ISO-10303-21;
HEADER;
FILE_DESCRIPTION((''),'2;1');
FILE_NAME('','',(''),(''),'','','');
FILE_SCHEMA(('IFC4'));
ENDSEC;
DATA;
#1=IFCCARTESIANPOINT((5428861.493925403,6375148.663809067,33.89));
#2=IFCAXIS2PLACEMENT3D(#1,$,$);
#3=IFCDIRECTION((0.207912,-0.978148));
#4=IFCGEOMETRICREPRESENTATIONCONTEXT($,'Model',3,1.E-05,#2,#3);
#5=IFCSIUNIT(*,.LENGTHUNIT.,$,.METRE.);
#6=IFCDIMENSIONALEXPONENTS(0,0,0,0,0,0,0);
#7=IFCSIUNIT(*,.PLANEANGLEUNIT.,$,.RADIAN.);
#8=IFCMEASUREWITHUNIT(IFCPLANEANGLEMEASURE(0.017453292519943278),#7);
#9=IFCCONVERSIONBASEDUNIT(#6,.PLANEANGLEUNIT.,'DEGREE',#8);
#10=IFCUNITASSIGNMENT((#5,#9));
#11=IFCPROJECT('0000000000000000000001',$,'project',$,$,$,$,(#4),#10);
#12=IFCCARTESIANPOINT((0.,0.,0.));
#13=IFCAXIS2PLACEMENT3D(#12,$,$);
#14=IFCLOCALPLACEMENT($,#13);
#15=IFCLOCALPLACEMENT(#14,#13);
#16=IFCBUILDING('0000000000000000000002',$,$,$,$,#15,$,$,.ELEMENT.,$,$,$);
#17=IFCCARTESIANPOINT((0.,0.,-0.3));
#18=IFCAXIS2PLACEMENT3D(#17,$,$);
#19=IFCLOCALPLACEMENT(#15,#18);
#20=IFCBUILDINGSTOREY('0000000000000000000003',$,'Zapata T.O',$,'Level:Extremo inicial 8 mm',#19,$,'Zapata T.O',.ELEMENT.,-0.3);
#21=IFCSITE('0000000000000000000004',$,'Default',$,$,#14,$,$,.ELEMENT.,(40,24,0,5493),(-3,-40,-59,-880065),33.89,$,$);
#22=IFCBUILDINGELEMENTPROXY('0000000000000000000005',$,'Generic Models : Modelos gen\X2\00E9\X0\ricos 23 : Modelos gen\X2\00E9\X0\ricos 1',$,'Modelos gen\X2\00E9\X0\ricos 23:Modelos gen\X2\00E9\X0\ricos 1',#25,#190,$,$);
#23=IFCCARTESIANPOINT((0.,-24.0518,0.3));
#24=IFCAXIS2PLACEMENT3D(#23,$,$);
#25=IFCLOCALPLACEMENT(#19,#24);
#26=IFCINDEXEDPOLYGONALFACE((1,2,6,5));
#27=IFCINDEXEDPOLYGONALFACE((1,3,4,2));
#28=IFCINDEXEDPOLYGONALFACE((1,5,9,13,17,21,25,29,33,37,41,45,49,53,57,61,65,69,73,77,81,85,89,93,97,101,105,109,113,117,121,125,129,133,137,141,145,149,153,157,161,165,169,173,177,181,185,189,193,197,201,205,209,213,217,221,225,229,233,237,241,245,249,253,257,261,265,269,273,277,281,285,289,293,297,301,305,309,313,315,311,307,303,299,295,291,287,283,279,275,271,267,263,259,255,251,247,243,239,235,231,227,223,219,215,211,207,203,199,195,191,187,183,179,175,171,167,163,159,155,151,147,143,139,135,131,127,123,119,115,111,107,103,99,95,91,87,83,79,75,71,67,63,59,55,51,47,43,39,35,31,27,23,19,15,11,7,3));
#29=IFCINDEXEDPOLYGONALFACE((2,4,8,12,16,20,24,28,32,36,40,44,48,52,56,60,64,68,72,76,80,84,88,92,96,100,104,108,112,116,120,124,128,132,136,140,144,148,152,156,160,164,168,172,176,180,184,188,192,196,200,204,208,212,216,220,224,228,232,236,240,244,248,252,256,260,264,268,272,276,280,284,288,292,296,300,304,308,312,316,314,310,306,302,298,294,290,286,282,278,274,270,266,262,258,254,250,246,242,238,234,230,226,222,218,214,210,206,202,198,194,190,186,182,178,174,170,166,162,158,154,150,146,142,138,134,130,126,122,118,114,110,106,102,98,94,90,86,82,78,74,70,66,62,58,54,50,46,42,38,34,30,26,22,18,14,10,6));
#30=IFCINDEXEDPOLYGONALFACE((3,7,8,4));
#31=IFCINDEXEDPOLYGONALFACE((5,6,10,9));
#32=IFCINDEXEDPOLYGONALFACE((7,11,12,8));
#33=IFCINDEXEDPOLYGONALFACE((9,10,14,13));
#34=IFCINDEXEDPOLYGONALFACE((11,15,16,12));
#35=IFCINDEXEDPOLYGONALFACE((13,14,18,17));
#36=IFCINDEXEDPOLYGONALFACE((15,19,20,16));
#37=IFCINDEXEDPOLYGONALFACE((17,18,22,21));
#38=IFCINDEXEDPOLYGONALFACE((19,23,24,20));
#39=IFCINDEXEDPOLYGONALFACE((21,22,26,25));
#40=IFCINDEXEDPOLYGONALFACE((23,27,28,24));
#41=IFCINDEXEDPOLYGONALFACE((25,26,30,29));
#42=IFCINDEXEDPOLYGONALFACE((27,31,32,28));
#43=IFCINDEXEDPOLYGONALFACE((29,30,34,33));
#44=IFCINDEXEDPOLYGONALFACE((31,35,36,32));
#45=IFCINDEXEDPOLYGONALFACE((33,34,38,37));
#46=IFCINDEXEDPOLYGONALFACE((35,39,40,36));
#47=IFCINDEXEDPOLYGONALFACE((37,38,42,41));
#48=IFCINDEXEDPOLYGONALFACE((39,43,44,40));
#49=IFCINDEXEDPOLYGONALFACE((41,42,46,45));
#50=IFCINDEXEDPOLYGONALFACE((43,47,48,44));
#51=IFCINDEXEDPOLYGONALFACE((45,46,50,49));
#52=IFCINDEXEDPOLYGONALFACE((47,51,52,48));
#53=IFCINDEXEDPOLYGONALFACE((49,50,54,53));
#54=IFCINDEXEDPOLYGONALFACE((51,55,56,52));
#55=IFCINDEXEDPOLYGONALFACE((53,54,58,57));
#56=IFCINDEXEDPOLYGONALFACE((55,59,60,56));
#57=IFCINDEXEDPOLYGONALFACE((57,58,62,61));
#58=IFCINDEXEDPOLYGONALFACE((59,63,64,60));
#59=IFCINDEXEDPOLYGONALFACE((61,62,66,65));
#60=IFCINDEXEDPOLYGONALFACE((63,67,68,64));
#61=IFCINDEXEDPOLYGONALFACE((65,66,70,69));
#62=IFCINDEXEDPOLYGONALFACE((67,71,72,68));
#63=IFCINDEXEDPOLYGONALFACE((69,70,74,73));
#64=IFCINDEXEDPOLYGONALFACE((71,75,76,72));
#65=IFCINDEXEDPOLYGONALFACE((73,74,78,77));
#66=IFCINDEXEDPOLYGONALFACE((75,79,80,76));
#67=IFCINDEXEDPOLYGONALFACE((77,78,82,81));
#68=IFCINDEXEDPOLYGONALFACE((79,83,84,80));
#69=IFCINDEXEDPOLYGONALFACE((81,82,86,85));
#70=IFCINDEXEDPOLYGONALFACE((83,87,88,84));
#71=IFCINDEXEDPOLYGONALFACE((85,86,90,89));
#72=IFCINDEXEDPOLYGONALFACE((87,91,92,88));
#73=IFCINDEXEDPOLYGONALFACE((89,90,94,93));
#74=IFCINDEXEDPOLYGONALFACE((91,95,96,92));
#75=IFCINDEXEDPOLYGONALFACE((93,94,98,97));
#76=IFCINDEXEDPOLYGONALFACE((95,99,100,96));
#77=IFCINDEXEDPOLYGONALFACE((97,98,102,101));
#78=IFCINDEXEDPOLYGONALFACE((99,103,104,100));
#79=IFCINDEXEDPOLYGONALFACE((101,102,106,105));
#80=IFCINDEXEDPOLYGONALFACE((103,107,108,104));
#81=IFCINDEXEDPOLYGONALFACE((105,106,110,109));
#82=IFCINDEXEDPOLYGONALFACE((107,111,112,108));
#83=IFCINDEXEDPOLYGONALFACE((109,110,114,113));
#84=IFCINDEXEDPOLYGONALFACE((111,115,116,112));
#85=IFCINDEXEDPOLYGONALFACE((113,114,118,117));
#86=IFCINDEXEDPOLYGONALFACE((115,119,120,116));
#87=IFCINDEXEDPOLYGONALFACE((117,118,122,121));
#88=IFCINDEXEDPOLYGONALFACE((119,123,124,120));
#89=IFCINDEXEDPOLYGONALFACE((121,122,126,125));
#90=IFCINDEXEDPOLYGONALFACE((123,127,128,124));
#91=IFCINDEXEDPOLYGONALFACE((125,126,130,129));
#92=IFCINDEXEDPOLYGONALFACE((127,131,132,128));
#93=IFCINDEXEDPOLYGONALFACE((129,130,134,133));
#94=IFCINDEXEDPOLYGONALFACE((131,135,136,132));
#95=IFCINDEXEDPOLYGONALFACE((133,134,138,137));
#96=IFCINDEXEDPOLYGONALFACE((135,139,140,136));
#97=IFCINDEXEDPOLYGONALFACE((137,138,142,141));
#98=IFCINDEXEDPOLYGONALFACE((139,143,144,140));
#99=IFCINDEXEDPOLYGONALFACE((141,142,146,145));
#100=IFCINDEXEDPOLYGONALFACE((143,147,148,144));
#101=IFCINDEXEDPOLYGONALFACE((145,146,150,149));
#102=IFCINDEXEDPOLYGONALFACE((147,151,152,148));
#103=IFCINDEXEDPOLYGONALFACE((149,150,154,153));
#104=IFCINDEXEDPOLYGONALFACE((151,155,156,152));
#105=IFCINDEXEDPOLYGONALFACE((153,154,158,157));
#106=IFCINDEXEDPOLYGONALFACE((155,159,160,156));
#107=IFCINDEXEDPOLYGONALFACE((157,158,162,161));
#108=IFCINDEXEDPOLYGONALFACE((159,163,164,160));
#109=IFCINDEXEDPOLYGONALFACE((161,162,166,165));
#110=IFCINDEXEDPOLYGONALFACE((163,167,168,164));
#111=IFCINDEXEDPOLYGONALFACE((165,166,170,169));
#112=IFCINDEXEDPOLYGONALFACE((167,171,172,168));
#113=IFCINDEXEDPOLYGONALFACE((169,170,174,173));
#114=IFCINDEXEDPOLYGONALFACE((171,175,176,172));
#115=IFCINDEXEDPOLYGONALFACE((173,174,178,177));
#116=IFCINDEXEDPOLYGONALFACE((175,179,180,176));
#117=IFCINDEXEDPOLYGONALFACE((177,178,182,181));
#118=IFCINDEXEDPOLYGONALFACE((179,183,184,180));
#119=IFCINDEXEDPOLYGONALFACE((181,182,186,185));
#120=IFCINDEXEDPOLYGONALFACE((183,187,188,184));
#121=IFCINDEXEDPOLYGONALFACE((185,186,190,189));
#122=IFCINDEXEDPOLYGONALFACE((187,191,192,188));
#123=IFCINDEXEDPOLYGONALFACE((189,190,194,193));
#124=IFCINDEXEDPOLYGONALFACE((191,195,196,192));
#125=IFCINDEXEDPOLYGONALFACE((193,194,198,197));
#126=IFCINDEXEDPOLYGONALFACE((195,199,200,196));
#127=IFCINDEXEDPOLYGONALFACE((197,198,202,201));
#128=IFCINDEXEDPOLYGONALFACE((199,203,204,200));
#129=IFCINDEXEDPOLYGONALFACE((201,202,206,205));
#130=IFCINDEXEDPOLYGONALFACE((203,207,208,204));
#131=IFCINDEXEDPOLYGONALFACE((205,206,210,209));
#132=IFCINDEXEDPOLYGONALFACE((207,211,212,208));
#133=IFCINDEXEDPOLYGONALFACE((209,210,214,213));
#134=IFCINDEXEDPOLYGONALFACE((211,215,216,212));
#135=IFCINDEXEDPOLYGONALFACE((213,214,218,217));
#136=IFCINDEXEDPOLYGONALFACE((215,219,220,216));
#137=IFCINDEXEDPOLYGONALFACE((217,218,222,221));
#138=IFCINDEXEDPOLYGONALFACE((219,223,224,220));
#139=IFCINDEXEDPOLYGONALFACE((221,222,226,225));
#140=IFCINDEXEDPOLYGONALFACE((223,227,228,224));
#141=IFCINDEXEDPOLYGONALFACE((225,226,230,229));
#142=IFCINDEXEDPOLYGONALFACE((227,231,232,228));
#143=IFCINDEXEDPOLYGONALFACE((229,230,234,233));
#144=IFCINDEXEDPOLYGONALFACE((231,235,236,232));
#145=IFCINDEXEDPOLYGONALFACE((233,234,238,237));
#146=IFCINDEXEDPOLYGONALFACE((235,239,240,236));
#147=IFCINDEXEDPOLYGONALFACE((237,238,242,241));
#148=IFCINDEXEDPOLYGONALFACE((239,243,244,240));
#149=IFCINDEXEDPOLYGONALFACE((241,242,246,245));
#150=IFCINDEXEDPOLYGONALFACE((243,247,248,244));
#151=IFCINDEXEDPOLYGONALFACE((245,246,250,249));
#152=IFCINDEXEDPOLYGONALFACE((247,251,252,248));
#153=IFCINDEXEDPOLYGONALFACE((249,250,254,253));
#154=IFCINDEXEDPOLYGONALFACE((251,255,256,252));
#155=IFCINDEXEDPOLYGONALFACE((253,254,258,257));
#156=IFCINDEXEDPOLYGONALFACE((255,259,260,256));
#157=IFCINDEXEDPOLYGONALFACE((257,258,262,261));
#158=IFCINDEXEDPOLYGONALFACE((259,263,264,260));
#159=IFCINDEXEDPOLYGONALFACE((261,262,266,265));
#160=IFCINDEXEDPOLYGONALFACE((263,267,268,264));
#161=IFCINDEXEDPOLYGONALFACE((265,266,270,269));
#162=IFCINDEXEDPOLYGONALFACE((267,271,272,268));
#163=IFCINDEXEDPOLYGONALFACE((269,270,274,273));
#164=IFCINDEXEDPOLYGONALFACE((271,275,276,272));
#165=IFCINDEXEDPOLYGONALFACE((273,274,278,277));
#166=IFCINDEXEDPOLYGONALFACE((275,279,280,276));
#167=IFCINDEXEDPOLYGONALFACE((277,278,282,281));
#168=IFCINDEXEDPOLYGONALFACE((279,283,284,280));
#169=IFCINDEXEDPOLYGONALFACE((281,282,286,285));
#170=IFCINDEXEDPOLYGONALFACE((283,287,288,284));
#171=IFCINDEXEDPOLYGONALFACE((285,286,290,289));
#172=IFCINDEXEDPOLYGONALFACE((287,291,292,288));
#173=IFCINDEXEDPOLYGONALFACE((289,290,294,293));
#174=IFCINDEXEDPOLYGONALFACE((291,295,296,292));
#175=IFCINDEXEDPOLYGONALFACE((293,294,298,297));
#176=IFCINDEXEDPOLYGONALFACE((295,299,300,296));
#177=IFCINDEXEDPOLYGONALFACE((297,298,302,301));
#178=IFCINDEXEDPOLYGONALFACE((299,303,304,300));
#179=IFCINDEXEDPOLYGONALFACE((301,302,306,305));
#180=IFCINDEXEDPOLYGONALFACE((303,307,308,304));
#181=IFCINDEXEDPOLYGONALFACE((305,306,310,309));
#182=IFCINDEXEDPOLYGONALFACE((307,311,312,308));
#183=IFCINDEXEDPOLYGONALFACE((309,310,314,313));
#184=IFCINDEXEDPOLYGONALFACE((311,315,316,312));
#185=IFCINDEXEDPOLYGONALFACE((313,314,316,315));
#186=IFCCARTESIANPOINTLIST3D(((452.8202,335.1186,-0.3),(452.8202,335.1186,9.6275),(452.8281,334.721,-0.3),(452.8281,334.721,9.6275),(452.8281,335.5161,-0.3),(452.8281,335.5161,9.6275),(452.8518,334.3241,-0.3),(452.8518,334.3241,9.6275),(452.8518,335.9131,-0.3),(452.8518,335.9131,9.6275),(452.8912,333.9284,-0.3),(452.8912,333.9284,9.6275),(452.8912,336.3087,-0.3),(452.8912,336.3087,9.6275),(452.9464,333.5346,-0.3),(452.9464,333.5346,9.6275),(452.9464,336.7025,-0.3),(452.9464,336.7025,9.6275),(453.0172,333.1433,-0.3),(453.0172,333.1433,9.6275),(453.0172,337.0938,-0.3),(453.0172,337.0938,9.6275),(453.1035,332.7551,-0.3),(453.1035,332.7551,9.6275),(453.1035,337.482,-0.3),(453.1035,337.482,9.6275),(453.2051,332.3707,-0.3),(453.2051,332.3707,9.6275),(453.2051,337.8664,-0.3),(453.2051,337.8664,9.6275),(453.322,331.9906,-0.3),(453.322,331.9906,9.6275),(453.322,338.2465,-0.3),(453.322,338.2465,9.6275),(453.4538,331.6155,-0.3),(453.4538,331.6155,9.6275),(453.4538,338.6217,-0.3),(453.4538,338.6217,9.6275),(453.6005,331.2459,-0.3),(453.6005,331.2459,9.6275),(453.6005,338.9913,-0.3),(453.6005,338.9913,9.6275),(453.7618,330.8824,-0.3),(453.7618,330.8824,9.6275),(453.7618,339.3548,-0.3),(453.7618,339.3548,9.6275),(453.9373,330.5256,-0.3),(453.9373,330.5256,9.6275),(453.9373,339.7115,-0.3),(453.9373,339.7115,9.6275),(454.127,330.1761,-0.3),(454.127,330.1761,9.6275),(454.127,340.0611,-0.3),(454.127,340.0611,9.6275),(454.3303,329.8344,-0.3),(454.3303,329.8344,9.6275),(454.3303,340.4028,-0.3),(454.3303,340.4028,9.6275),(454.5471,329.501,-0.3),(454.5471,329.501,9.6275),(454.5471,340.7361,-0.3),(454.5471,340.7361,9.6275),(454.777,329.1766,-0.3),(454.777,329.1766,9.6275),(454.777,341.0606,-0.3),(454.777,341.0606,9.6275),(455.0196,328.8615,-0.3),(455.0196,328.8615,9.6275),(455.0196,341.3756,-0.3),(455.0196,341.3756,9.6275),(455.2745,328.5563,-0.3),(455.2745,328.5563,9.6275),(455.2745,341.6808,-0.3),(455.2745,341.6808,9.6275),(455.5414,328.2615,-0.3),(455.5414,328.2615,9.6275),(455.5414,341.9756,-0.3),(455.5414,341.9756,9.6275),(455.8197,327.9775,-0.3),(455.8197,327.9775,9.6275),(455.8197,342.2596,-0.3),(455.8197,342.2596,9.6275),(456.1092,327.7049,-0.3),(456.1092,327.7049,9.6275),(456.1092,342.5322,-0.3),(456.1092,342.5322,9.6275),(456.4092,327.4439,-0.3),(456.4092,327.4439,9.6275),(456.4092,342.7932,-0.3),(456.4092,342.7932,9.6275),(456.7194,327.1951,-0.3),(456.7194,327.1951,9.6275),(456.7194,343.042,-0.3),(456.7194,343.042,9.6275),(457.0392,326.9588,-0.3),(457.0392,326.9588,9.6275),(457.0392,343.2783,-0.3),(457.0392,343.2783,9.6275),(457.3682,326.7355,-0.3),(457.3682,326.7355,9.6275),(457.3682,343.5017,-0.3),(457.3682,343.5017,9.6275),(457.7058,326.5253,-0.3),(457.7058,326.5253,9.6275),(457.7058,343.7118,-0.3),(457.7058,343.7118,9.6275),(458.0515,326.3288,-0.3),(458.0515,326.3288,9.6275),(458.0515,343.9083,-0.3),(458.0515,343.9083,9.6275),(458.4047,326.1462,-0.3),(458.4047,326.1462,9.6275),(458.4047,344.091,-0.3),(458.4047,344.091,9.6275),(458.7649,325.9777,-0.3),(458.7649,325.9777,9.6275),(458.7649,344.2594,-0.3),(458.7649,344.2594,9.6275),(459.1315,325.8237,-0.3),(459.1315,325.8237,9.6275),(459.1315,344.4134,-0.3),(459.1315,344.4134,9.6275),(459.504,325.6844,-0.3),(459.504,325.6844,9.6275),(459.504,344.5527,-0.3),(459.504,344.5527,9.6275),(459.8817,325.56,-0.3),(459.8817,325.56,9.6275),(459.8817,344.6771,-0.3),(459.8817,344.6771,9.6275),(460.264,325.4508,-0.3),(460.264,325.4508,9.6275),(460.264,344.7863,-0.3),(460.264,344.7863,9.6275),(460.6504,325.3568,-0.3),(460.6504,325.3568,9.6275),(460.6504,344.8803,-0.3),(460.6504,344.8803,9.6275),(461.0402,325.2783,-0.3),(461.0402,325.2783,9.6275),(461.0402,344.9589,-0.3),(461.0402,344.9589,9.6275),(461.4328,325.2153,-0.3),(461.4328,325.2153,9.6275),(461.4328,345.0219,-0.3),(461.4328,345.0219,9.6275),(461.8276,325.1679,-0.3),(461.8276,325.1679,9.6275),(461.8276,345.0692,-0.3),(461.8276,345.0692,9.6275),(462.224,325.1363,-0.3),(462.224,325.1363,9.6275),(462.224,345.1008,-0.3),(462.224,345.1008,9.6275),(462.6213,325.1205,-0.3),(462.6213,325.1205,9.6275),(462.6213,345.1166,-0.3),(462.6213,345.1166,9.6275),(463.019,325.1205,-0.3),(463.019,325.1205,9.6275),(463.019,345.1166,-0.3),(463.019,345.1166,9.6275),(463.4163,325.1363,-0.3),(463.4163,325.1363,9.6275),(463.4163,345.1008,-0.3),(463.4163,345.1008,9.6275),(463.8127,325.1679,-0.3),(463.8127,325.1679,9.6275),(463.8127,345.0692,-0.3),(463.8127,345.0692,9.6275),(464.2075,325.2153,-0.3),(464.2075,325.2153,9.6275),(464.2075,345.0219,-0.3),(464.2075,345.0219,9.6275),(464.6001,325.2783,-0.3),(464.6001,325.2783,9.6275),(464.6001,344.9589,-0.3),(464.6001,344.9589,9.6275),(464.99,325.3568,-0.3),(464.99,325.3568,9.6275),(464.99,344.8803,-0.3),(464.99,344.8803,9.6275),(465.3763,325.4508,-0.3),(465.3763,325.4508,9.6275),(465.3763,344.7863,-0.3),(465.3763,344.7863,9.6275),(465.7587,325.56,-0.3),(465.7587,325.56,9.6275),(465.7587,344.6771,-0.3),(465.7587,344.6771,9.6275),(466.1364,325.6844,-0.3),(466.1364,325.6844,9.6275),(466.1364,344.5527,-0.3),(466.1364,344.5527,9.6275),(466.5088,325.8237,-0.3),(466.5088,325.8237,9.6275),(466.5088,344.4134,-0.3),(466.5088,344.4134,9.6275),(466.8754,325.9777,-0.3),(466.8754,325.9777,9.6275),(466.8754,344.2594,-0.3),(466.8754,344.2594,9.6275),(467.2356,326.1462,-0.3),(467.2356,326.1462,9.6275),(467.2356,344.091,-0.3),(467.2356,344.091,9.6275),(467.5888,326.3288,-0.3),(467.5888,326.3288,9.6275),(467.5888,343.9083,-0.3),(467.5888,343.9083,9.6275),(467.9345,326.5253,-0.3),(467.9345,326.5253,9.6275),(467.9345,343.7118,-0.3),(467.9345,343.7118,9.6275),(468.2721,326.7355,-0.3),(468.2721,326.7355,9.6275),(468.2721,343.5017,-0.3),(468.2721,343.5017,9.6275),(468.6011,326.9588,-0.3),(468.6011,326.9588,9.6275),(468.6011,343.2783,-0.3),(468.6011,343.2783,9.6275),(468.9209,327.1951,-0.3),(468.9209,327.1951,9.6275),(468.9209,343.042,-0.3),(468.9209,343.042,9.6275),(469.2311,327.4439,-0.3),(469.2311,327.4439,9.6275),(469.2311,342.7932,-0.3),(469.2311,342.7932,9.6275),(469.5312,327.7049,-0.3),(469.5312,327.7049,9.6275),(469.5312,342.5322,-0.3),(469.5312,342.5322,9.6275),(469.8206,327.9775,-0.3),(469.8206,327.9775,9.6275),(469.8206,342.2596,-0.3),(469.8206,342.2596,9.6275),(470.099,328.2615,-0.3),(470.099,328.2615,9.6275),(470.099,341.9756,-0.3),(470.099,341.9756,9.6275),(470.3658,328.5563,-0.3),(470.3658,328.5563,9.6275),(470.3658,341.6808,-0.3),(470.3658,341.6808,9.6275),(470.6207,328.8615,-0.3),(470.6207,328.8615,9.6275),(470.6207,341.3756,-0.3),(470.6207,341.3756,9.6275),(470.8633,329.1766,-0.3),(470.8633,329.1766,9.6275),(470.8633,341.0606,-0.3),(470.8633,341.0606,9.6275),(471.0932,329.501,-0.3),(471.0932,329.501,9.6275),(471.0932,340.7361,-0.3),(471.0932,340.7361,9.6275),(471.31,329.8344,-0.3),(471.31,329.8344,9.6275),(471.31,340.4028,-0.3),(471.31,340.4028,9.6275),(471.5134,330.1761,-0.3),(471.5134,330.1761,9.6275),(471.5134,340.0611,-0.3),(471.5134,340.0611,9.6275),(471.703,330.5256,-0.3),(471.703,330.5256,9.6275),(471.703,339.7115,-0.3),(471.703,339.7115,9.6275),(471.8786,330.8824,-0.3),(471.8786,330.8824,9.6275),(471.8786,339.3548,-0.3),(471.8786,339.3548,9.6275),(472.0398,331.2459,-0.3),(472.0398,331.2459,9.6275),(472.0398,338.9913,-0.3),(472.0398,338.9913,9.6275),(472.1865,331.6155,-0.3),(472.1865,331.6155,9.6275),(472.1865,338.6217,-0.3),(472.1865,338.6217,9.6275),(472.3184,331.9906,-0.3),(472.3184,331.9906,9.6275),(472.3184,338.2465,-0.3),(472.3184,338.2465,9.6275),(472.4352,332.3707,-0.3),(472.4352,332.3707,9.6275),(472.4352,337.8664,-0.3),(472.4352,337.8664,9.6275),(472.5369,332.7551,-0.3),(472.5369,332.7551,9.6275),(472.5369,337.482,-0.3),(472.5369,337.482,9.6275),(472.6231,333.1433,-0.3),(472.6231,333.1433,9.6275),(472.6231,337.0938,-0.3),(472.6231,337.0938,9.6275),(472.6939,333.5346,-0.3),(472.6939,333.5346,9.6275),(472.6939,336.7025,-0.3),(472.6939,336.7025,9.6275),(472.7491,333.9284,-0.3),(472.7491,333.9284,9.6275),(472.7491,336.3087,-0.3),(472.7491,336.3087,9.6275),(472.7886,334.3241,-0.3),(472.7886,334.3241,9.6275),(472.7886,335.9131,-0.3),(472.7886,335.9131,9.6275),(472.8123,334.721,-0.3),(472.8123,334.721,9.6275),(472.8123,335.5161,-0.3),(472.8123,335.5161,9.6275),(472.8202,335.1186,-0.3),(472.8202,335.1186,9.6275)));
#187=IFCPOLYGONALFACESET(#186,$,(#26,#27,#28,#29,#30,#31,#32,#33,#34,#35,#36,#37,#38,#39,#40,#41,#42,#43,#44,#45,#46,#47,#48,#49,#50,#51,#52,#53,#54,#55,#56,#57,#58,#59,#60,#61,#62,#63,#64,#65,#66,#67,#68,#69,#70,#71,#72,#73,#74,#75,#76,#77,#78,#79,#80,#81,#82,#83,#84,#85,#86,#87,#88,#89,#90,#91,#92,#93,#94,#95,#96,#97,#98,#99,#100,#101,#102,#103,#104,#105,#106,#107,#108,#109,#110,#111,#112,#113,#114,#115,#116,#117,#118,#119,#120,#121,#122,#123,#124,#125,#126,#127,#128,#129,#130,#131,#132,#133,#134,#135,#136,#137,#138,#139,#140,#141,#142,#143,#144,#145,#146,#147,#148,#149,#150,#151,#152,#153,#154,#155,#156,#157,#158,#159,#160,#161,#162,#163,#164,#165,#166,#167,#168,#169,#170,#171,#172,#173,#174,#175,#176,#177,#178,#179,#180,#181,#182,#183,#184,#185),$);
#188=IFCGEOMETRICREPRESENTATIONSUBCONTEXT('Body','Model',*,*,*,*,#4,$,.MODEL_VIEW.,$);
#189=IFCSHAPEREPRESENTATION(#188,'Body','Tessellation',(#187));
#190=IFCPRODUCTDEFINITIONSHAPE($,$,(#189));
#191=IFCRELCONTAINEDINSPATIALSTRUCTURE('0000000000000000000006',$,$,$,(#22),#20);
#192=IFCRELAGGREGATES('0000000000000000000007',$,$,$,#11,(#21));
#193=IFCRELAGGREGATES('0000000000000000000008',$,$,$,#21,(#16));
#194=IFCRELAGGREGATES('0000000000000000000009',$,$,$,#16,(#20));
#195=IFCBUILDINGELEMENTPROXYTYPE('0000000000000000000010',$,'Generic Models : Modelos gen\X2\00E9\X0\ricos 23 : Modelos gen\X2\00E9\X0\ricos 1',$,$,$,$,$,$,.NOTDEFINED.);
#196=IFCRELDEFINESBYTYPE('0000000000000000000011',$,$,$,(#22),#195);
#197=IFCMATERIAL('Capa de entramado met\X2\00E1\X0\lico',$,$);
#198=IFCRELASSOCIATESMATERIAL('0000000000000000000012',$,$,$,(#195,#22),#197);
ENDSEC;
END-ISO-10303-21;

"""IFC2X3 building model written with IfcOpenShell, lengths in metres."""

from ifc_helpers import new_model, entity, si_unit, converted_unit, direction, frame, origin, origin_2d_with_axis, place, context, subcontext, project, spatial, circle, extrude, source, transform, mapped, material, type_object, type_shapes, element, save


model = new_model("IFC2X3")

# Units and contexts
model_context = context("Model", 3, precision=1e-05, world=frame((5428861.493925403, 6375148.663809067, 33.89)), true_north=direction((0.207912, -0.978148)))
body_context = subcontext(model_context, "Body", "Model", "MODEL_VIEW")
ifc_project = project(units=[si_unit("LENGTHUNIT", "METRE"), converted_unit("PLANEANGLEUNIT", "DEGREE", entity("IfcPlaneAngleMeasure", 0.017453292519943278), si_unit("PLANEANGLEUNIT", "RADIAN"), dimensions=[0, 0, 0, 0, 0, 0, 0])], contexts=[model_context])

# Site, building, storey
site_placement = place(None, origin())
site = spatial("IfcSite", under=ifc_project, at=site_placement, Name="Default", CompositionType="ELEMENT", RefLatitude=(40, 24, 0, 5493), RefLongitude=(-3, -40, -59, -880065), RefElevation=33.89)
building_placement = place(site_placement, origin())
building = spatial("IfcBuilding", under=site, at=building_placement, CompositionType="ELEMENT")
storey_placement = place(building_placement, frame((0.0, 0.0, -0.3)))
storey = spatial("IfcBuildingStorey", under=building, at=storey_placement, Name="Zapata T.O", ObjectType="Level:Extremo inicial 8 mm", LongName="Zapata T.O", CompositionType="ELEMENT", Elevation=-0.3)

# Building element proxy
ifc_material = material(Name="Capa de entramado metálico")
building_element_proxy_type_1 = type_object("IfcBuildingElementProxyType", Name="Generic Models : Modelos genéricos 23 : Modelos genéricos 1", PredefinedType="NOTDEFINED", material=ifc_material)
shared_shape_1 = source(origin(), body_context, "Body", "SweptSolid", [
    extrude(circle(Radius=10.0, at=origin_2d_with_axis()), frame((462.8202, 335.1186, -0.3)), (0.0, 0.0, 1.0), 9.9275),
])
type_shapes(building_element_proxy_type_1, [shared_shape_1])
proxy_1_placement = place(storey_placement, frame((0.0, -24.0518, 0.3)))
element("IfcBuildingElementProxy", 1, at=proxy_1_placement, inside=storey, type_object=building_element_proxy_type_1, material=ifc_material, Name="Generic Models : Modelos genéricos 23 : Modelos genéricos 1", ObjectType="Modelos genéricos 23:Modelos genéricos 1", context=body_context, shape_type="MappedRepresentation", body=[
    mapped(shared_shape_1, transform((0.0, 0.0, 0.0), scale=1.0)),
])

save(model, "model.ifc")
